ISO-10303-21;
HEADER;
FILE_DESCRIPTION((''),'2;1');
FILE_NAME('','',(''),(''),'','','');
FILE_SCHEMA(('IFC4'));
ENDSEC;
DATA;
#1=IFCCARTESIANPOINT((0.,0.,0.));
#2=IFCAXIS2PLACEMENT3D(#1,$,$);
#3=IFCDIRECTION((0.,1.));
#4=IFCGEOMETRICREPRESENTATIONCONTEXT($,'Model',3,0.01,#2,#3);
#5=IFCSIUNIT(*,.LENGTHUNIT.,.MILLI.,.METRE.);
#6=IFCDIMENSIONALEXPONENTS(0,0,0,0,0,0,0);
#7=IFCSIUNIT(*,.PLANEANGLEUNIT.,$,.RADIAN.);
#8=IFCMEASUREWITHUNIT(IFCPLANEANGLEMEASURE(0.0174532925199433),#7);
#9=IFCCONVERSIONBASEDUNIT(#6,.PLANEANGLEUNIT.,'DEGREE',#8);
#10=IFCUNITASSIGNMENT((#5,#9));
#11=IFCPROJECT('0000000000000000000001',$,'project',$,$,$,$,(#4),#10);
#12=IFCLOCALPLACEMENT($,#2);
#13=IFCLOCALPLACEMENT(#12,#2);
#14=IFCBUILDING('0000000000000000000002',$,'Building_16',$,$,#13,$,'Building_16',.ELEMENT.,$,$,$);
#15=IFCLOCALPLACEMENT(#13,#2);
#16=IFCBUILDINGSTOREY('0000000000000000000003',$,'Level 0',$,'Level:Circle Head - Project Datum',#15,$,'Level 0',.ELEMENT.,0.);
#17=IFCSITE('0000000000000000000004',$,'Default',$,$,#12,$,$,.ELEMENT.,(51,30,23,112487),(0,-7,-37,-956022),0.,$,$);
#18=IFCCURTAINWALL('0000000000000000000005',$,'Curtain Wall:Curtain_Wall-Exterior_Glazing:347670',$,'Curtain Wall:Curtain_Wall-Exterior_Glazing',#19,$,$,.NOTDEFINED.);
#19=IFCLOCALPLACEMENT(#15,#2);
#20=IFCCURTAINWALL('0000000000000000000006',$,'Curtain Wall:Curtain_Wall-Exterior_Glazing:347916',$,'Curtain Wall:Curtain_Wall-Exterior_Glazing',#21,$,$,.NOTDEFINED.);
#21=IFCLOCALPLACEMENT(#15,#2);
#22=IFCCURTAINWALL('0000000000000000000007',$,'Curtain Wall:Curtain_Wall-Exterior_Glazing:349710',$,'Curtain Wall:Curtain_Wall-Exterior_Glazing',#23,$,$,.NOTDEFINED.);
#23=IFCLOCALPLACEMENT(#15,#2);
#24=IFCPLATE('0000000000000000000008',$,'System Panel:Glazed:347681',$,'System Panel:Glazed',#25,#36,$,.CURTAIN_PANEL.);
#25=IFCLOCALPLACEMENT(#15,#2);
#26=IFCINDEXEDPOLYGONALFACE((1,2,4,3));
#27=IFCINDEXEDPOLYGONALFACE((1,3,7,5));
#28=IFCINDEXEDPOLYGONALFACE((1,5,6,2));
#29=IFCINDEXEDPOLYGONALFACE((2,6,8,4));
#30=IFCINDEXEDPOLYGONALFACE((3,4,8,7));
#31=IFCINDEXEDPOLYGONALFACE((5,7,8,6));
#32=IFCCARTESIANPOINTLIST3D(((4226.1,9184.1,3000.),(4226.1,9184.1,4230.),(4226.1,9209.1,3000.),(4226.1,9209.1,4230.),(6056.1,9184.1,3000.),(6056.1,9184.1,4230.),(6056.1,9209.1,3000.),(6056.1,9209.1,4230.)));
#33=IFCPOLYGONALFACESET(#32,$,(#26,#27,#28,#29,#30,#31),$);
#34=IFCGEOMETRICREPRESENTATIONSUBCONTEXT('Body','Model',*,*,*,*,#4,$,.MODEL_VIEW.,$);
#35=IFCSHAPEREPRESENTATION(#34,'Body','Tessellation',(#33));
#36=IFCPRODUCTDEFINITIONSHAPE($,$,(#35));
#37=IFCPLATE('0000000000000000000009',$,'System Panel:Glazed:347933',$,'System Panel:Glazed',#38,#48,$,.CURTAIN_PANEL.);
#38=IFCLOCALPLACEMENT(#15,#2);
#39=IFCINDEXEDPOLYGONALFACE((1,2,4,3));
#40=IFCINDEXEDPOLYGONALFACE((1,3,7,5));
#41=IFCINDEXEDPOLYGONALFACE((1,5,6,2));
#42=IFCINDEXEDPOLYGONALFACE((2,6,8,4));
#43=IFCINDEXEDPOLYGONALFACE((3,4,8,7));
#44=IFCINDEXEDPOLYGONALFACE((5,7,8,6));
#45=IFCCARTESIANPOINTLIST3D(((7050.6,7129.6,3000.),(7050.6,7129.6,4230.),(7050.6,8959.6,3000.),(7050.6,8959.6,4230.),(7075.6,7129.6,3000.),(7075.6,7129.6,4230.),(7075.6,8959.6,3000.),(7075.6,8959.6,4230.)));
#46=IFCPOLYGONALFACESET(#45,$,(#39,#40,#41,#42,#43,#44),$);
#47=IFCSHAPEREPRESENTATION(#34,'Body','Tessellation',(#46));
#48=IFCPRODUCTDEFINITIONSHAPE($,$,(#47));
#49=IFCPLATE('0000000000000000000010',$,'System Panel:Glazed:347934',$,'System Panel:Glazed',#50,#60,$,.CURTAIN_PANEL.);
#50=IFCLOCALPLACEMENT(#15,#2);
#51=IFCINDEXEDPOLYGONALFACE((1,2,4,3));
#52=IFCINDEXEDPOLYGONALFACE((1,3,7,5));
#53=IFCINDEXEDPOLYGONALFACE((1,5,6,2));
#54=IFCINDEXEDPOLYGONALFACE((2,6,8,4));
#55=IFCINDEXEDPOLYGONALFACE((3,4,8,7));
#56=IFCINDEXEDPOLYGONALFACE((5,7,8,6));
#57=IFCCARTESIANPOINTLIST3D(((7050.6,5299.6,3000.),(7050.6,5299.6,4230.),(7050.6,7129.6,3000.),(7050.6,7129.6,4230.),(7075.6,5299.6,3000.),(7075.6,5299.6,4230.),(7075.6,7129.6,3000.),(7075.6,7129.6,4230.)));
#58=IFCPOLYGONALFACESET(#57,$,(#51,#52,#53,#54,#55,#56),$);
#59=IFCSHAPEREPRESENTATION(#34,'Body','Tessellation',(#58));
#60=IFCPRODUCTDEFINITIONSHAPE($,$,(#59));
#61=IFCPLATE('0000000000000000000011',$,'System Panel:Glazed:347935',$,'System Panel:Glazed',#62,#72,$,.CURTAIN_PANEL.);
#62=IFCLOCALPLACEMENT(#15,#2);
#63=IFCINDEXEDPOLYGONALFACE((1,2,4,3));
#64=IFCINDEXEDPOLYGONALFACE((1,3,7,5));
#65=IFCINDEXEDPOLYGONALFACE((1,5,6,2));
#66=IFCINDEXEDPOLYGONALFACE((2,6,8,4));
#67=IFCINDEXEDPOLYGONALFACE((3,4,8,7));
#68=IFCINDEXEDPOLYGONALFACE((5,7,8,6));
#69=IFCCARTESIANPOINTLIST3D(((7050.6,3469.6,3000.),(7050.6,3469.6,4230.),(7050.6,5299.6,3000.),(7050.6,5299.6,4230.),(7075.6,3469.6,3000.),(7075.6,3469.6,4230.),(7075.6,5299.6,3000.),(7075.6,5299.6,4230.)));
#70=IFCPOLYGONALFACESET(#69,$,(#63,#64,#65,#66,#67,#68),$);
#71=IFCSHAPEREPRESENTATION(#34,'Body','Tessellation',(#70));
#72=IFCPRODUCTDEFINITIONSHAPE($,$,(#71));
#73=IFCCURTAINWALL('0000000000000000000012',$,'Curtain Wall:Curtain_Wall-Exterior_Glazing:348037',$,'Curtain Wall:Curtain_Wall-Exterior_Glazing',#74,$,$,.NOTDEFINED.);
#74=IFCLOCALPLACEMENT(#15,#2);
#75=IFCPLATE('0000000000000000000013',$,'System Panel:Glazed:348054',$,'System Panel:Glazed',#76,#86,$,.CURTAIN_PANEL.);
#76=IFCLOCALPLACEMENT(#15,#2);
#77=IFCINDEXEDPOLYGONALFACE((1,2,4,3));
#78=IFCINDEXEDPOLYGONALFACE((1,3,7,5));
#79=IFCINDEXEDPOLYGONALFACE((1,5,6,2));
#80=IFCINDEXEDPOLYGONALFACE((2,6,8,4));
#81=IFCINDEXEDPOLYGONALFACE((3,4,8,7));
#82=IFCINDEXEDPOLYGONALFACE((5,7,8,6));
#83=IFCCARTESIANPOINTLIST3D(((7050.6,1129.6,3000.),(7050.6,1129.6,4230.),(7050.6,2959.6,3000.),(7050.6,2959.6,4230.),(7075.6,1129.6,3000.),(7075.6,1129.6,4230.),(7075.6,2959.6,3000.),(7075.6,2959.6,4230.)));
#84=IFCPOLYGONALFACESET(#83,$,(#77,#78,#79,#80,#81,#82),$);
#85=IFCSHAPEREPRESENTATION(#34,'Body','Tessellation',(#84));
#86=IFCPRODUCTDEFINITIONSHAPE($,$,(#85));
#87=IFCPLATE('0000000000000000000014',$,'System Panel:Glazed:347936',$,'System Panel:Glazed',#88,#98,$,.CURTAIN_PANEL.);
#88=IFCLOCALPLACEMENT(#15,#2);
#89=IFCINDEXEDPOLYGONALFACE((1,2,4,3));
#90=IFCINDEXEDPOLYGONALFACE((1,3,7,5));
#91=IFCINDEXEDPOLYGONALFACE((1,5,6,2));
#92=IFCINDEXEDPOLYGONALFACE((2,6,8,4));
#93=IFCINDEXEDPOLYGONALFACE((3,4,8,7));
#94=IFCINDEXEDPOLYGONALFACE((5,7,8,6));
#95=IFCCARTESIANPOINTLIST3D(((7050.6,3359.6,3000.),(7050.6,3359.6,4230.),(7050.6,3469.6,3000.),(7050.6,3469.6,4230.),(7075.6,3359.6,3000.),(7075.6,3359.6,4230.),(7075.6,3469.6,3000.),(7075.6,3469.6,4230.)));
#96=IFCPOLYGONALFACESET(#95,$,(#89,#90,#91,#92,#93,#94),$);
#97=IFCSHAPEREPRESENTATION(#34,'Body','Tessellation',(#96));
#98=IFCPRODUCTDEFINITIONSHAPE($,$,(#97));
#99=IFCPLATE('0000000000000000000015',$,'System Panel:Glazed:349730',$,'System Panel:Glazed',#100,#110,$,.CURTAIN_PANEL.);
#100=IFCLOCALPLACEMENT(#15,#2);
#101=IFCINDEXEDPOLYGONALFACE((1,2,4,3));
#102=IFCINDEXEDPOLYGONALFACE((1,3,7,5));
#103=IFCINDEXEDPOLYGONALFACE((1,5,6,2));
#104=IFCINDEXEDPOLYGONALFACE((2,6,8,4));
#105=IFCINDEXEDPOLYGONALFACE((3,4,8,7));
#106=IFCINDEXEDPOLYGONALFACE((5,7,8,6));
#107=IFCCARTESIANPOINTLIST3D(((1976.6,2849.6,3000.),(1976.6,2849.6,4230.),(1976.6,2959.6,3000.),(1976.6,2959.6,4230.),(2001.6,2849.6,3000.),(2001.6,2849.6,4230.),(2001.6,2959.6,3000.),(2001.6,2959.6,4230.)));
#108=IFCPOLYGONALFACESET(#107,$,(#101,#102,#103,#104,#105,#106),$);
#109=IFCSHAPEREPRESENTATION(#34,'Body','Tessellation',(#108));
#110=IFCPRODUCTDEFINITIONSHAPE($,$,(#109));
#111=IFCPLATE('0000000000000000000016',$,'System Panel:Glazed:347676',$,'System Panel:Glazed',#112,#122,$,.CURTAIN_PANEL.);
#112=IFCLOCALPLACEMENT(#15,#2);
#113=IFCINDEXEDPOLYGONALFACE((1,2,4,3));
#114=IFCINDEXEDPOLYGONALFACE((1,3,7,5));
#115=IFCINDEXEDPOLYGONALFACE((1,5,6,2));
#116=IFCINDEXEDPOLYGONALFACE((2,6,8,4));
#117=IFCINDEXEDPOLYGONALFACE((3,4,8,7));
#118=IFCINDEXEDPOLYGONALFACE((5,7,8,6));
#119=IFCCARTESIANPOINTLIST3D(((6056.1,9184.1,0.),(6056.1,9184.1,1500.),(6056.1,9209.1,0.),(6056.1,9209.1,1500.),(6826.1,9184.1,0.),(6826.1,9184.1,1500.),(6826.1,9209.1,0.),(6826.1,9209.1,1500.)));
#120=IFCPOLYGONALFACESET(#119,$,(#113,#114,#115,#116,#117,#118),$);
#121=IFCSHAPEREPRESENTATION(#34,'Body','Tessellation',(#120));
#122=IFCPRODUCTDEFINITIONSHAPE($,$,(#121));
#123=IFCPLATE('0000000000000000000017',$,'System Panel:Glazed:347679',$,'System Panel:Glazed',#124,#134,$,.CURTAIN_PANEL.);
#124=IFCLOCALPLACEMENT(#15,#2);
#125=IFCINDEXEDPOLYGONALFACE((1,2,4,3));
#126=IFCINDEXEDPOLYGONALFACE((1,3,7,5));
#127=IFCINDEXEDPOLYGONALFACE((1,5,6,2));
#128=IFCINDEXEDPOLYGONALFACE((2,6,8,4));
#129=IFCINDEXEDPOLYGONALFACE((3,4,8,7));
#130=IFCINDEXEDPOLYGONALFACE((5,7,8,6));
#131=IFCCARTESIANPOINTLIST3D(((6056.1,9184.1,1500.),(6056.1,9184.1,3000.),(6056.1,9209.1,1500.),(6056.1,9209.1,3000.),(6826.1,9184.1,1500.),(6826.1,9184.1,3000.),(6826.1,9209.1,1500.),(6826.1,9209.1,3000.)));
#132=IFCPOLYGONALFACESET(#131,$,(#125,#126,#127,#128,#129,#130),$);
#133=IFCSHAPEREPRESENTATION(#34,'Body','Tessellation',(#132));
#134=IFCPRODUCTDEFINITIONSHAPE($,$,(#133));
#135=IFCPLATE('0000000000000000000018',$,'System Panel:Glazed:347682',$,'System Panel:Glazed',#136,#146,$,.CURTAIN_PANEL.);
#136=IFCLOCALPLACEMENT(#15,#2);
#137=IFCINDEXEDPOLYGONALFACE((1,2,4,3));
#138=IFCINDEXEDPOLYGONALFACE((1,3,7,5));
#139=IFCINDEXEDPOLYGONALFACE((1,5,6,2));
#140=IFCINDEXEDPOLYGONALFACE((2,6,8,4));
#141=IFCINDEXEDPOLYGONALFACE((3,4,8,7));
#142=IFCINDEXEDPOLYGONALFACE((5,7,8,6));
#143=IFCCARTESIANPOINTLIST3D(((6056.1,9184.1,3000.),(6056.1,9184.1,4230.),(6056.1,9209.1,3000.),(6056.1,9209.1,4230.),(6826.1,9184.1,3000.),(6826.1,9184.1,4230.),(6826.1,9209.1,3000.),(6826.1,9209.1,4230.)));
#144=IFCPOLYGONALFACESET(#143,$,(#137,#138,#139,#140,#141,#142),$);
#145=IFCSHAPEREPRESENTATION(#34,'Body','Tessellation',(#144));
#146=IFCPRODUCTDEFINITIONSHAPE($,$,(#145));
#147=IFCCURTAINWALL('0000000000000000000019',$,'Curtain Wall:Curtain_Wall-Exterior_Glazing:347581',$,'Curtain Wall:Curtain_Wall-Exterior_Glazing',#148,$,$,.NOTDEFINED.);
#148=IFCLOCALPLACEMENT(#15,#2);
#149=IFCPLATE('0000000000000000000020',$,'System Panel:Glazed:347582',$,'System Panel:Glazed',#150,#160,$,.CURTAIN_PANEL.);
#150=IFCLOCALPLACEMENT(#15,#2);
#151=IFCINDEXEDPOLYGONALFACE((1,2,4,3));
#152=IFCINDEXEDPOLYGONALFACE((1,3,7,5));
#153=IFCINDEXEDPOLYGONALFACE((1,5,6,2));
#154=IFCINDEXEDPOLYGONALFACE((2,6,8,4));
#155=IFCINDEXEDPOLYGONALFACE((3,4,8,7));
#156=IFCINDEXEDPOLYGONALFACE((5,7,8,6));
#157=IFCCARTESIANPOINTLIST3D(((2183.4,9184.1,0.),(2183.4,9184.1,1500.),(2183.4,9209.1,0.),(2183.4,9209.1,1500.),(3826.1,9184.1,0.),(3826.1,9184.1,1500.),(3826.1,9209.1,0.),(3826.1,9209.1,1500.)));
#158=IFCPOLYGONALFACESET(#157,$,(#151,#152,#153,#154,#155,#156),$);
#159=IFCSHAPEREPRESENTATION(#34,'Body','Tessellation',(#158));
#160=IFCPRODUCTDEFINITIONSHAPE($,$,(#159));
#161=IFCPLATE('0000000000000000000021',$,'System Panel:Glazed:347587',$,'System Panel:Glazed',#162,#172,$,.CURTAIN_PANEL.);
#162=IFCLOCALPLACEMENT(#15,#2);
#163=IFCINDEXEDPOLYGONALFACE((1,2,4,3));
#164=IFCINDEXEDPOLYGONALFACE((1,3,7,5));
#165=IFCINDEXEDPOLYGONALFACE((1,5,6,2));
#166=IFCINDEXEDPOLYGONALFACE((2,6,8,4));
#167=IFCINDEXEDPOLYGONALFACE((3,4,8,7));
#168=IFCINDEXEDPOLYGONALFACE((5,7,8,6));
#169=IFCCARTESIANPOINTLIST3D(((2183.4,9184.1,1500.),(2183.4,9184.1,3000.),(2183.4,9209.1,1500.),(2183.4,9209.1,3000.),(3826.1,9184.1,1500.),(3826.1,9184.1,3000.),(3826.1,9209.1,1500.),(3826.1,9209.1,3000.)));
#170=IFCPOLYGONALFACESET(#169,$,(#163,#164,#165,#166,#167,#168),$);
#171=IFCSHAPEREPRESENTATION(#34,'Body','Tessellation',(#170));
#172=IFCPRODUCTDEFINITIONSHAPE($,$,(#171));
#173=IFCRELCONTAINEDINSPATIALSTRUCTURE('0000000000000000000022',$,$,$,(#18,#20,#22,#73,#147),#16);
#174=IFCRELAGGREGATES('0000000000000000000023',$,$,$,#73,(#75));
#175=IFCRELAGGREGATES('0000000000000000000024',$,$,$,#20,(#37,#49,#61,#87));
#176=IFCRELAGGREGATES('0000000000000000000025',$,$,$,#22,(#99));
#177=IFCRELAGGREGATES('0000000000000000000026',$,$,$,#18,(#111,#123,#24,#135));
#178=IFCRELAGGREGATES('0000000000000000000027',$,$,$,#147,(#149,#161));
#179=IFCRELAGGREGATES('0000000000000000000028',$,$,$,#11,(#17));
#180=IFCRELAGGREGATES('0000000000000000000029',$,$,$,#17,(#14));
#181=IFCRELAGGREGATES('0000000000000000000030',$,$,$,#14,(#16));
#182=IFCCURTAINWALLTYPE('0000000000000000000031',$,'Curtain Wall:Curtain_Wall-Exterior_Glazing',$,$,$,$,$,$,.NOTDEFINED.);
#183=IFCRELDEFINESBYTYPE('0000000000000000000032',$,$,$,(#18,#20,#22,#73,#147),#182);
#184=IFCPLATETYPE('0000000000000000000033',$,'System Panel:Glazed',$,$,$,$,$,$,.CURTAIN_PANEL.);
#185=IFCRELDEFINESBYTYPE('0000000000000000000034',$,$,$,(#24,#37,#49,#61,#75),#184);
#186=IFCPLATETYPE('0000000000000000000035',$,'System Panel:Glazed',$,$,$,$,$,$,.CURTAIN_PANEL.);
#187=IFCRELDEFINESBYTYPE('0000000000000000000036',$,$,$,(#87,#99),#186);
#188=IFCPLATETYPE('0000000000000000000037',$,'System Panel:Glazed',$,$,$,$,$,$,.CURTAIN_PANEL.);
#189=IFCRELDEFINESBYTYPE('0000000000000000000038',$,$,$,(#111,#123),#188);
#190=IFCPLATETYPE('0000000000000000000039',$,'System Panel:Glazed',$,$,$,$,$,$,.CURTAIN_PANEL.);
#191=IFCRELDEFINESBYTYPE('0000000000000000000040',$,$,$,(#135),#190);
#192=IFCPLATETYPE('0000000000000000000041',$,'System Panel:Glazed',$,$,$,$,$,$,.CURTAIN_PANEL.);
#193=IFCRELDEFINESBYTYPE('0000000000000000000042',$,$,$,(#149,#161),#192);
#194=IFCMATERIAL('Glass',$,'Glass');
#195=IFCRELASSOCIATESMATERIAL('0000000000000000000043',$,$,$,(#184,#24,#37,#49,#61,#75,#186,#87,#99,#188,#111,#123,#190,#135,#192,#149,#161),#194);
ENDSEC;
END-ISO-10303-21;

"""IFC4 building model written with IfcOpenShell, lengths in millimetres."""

from ifc_helpers import new_model, entity, si_unit, converted_unit, direction, frame, origin, place, context, subcontext, project, spatial, indexed_curve, outline, extrude, source, transform, mapped, material, type_object, type_shapes, element, aggregate, save


model = new_model("IFC4")

# Units and contexts
model_context = context("Model", 3, precision=0.01, world=origin(), true_north=direction((0.0, 1.0)))
body_context = subcontext(model_context, "Body", "Model", "MODEL_VIEW")
ifc_project = project(units=[si_unit("LENGTHUNIT", "METRE", prefix="MILLI"), converted_unit("PLANEANGLEUNIT", "DEGREE", entity("IfcPlaneAngleMeasure", 0.0174532925199433), si_unit("PLANEANGLEUNIT", "RADIAN"), dimensions=[0, 0, 0, 0, 0, 0, 0])], contexts=[model_context])

# Site, building, storey
site_placement = place(None, origin())
site = spatial("IfcSite", under=ifc_project, at=site_placement, Name="Default", CompositionType="ELEMENT", RefLatitude=(51, 30, 23, 112487), RefLongitude=(0, -7, -37, -956022), RefElevation=0.0)
building_placement = place(site_placement, origin())
building = spatial("IfcBuilding", under=site, at=building_placement, Name="Building_16", LongName="Building_16", CompositionType="ELEMENT")
storey_placement = place(building_placement, origin())
storey = spatial("IfcBuildingStorey", under=building, at=storey_placement, Name="Level 0", ObjectType="Level:Circle Head - Project Datum", LongName="Level 0", CompositionType="ELEMENT", Elevation=0.0)

# Curtain walls
curtain_wall_type = type_object("IfcCurtainWallType", Name="Curtain Wall:Curtain_Wall-Exterior_Glazing", PredefinedType="NOTDEFINED")
curtain_wall_1_placement = place(storey_placement, origin())
curtain_wall_1 = element("IfcCurtainWall", 1, at=curtain_wall_1_placement, inside=storey, type_object=curtain_wall_type, Name="Curtain Wall:Curtain_Wall-Exterior_Glazing:347670", ObjectType="Curtain Wall:Curtain_Wall-Exterior_Glazing", PredefinedType="NOTDEFINED")
ifc_material_1 = material(Name="Glass", Category="Glass")
curtain_wall_2_placement = place(storey_placement, origin())
curtain_wall_2 = element("IfcCurtainWall", 2, at=curtain_wall_2_placement, inside=storey, type_object=curtain_wall_type, Name="Curtain Wall:Curtain_Wall-Exterior_Glazing:347916", ObjectType="Curtain Wall:Curtain_Wall-Exterior_Glazing", PredefinedType="NOTDEFINED")
curtain_wall_3_placement = place(storey_placement, origin())
curtain_wall_3 = element("IfcCurtainWall", 3, at=curtain_wall_3_placement, inside=storey, type_object=curtain_wall_type, Name="Curtain Wall:Curtain_Wall-Exterior_Glazing:349710", ObjectType="Curtain Wall:Curtain_Wall-Exterior_Glazing", PredefinedType="NOTDEFINED")

# Plates
plate_type_1 = type_object("IfcPlateType", Name="System Panel:Glazed", PredefinedType="CURTAIN_PANEL", material=ifc_material_1)
shared_shape_1 = source(origin(), body_context, "Body", "SweptSolid", [
    extrude(outline(indexed_curve([(-12.5, -915.0), (12.5, -915.0), (12.5, 915.0), (-12.5, 915.0), (-12.5, -915.0)], self_intersect=False)), frame((0.0, 37.0, 0.0), z_axis=(0.0, 0.0, 1.0), x_axis=(0.0, 1.0, 0.0)), (0.0, 0.0, 1.0), 1230.0),
])
type_shapes(plate_type_1, [shared_shape_1])
plate_1_placement = place(curtain_wall_1_placement, frame((5141.1, 9159.6, 3000.0)))
plate_1 = element("IfcPlate", 4, at=plate_1_placement, type_object=plate_type_1, material=ifc_material_1, Name="System Panel:Glazed:347681", ObjectType="System Panel:Glazed", PredefinedType="CURTAIN_PANEL", context=body_context, shape_type="MappedRepresentation", body=[
    mapped(shared_shape_1, transform((0.0, 0.0, 0.0), scale=1.0)),
])
plate_2_placement = place(curtain_wall_2_placement, frame((7026.1, 8044.6, 3000.0), z_axis=(0.0, 0.0, 1.0), x_axis=(0.0, -1.0, 0.0)))
plate_2 = element("IfcPlate", 5, at=plate_2_placement, type_object=plate_type_1, material=ifc_material_1, Name="System Panel:Glazed:347933", ObjectType="System Panel:Glazed", PredefinedType="CURTAIN_PANEL", context=body_context, shape_type="MappedRepresentation", body=[
    mapped(shared_shape_1, transform((0.0, 0.0, 0.0), scale=1.0)),
])
plate_3_placement = place(curtain_wall_2_placement, frame((7026.1, 6214.6, 3000.0), z_axis=(0.0, 0.0, 1.0), x_axis=(0.0, -1.0, 0.0)))
plate_3 = element("IfcPlate", 6, at=plate_3_placement, type_object=plate_type_1, material=ifc_material_1, Name="System Panel:Glazed:347934", ObjectType="System Panel:Glazed", PredefinedType="CURTAIN_PANEL", context=body_context, shape_type="MappedRepresentation", body=[
    mapped(shared_shape_1, transform((0.0, 0.0, 0.0), scale=1.0)),
])
plate_4_placement = place(curtain_wall_2_placement, frame((7026.1, 4384.6, 3000.0), z_axis=(0.0, 0.0, 1.0), x_axis=(0.0, -1.0, 0.0)))
plate_4 = element("IfcPlate", 7, at=plate_4_placement, type_object=plate_type_1, material=ifc_material_1, Name="System Panel:Glazed:347935", ObjectType="System Panel:Glazed", PredefinedType="CURTAIN_PANEL", context=body_context, shape_type="MappedRepresentation", body=[
    mapped(shared_shape_1, transform((0.0, 0.0, 0.0), scale=1.0)),
])

# Curtain wall, plate
curtain_wall_4_placement = place(storey_placement, origin())
curtain_wall_4 = element("IfcCurtainWall", 8, at=curtain_wall_4_placement, inside=storey, type_object=curtain_wall_type, Name="Curtain Wall:Curtain_Wall-Exterior_Glazing:348037", ObjectType="Curtain Wall:Curtain_Wall-Exterior_Glazing", PredefinedType="NOTDEFINED")
plate_5_placement = place(curtain_wall_4_placement, frame((7026.1, 2044.6, 3000.0), z_axis=(0.0, 0.0, 1.0), x_axis=(0.0, -1.0, 0.0)))
plate_5 = element("IfcPlate", 9, at=plate_5_placement, type_object=plate_type_1, material=ifc_material_1, Name="System Panel:Glazed:348054", ObjectType="System Panel:Glazed", PredefinedType="CURTAIN_PANEL", context=body_context, shape_type="MappedRepresentation", body=[
    mapped(shared_shape_1, transform((0.0, 0.0, 0.0), scale=1.0)),
])
aggregate(curtain_wall_4, [plate_5])

# Plates
plate_type_2 = type_object("IfcPlateType", Name="System Panel:Glazed", PredefinedType="CURTAIN_PANEL", material=ifc_material_1)
shared_shape_2 = source(origin(), body_context, "Body", "SweptSolid", [
    extrude(outline(indexed_curve([(-12.5, -55.0), (12.5, -55.0), (12.5, 55.0), (-12.5, 55.0), (-12.5, -55.0)], self_intersect=False)), frame((0.0, 37.0, 0.0), z_axis=(0.0, 0.0, 1.0), x_axis=(0.0, 1.0, 0.0)), (0.0, 0.0, 1.0), 1230.0),
])
type_shapes(plate_type_2, [shared_shape_2])
plate_6_placement = place(curtain_wall_2_placement, frame((7026.1, 3414.6, 3000.0), z_axis=(0.0, 0.0, 1.0), x_axis=(0.0, -1.0, 0.0)))
plate_6 = element("IfcPlate", 10, at=plate_6_placement, type_object=plate_type_2, material=ifc_material_1, Name="System Panel:Glazed:347936", ObjectType="System Panel:Glazed", PredefinedType="CURTAIN_PANEL", context=body_context, shape_type="MappedRepresentation", body=[
    mapped(shared_shape_2, transform((0.0, 0.0, 0.0), scale=1.0)),
])
aggregate(curtain_wall_2, [plate_2, plate_3, plate_4, plate_6])
plate_7_placement = place(curtain_wall_3_placement, frame((2026.1, 2904.6, 3000.0), z_axis=(0.0, 0.0, 1.0), x_axis=(0.0, 1.0, 0.0)))
plate_7 = element("IfcPlate", 11, at=plate_7_placement, type_object=plate_type_2, material=ifc_material_1, Name="System Panel:Glazed:349730", ObjectType="System Panel:Glazed", PredefinedType="CURTAIN_PANEL", context=body_context, shape_type="MappedRepresentation", body=[
    mapped(shared_shape_2, transform((0.0, 0.0, 0.0), scale=1.0)),
])
aggregate(curtain_wall_3, [plate_7])
plate_type_3 = type_object("IfcPlateType", Name="System Panel:Glazed", PredefinedType="CURTAIN_PANEL", material=ifc_material_1)
shared_shape_3 = source(origin(), body_context, "Body", "SweptSolid", [
    extrude(outline(indexed_curve([(-12.5, -385.0), (12.5, -385.0), (12.5, 385.0), (-12.5, 385.0), (-12.5, -385.0)], self_intersect=False)), frame((0.0, 37.0, 0.0), z_axis=(0.0, 0.0, 1.0), x_axis=(0.0, 1.0, 0.0)), (0.0, 0.0, 1.0), 1500.0),
])
type_shapes(plate_type_3, [shared_shape_3])
plate_8_placement = place(curtain_wall_1_placement, frame((6441.1, 9159.6, 0.0)))
plate_8 = element("IfcPlate", 12, at=plate_8_placement, type_object=plate_type_3, material=ifc_material_1, Name="System Panel:Glazed:347676", ObjectType="System Panel:Glazed", PredefinedType="CURTAIN_PANEL", context=body_context, shape_type="MappedRepresentation", body=[
    mapped(shared_shape_3, transform((0.0, 0.0, 0.0), scale=1.0)),
])
plate_9_placement = place(curtain_wall_1_placement, frame((6441.1, 9159.6, 1500.0)))
plate_9 = element("IfcPlate", 13, at=plate_9_placement, type_object=plate_type_3, material=ifc_material_1, Name="System Panel:Glazed:347679", ObjectType="System Panel:Glazed", PredefinedType="CURTAIN_PANEL", context=body_context, shape_type="MappedRepresentation", body=[
    mapped(shared_shape_3, transform((0.0, 0.0, 0.0), scale=1.0)),
])
plate_type_4 = type_object("IfcPlateType", Name="System Panel:Glazed", PredefinedType="CURTAIN_PANEL", material=ifc_material_1)
shared_shape_4 = source(origin(), body_context, "Body", "SweptSolid", [
    extrude(outline(indexed_curve([(-12.5, -385.0), (12.5, -385.0), (12.5, 385.0), (-12.5, 385.0), (-12.5, -385.0)], self_intersect=False)), frame((0.0, 37.0, 0.0), z_axis=(0.0, 0.0, 1.0), x_axis=(0.0, 1.0, 0.0)), (0.0, 0.0, 1.0), 1230.0),
])
type_shapes(plate_type_4, [shared_shape_4])
plate_10_placement = place(curtain_wall_1_placement, frame((6441.1, 9159.6, 3000.0)))
plate_10 = element("IfcPlate", 14, at=plate_10_placement, type_object=plate_type_4, material=ifc_material_1, Name="System Panel:Glazed:347682", ObjectType="System Panel:Glazed", PredefinedType="CURTAIN_PANEL", context=body_context, shape_type="MappedRepresentation", body=[
    mapped(shared_shape_4, transform((0.0, 0.0, 0.0), scale=1.0)),
])
aggregate(curtain_wall_1, [plate_8, plate_9, plate_1, plate_10])

# Curtain wall, plates
curtain_wall_5_placement = place(storey_placement, origin())
curtain_wall_5 = element("IfcCurtainWall", 15, at=curtain_wall_5_placement, inside=storey, type_object=curtain_wall_type, Name="Curtain Wall:Curtain_Wall-Exterior_Glazing:347581", ObjectType="Curtain Wall:Curtain_Wall-Exterior_Glazing", PredefinedType="NOTDEFINED")
plate_type_5 = type_object("IfcPlateType", Name="System Panel:Glazed", PredefinedType="CURTAIN_PANEL", material=ifc_material_1)
shared_shape_5 = source(origin(), body_context, "Body", "SweptSolid", [
    extrude(outline(indexed_curve([(-12.5, -821.4), (12.5, -821.4), (12.5, 821.4), (-12.5, 821.4), (-12.5, -821.4)], self_intersect=False)), frame((0.0, 37.0, 0.0), z_axis=(0.0, 0.0, 1.0), x_axis=(0.0, 1.0, 0.0)), (0.0, 0.0, 1.0), 1500.0),
])
type_shapes(plate_type_5, [shared_shape_5])
plate_11_placement = place(curtain_wall_5_placement, frame((3004.7, 9159.6, 0.0)))
plate_11 = element("IfcPlate", 16, at=plate_11_placement, type_object=plate_type_5, material=ifc_material_1, Name="System Panel:Glazed:347582", ObjectType="System Panel:Glazed", PredefinedType="CURTAIN_PANEL", context=body_context, shape_type="MappedRepresentation", body=[
    mapped(shared_shape_5, transform((0.0, 0.0, 0.0), scale=1.0)),
])
plate_12_placement = place(curtain_wall_5_placement, frame((3004.7, 9159.6, 1500.0)))
plate_12 = element("IfcPlate", 17, at=plate_12_placement, type_object=plate_type_5, material=ifc_material_1, Name="System Panel:Glazed:347587", ObjectType="System Panel:Glazed", PredefinedType="CURTAIN_PANEL", context=body_context, shape_type="MappedRepresentation", body=[
    mapped(shared_shape_5, transform((0.0, 0.0, 0.0), scale=1.0)),
])
aggregate(curtain_wall_5, [plate_11, plate_12])

save(model, "model.ifc")
